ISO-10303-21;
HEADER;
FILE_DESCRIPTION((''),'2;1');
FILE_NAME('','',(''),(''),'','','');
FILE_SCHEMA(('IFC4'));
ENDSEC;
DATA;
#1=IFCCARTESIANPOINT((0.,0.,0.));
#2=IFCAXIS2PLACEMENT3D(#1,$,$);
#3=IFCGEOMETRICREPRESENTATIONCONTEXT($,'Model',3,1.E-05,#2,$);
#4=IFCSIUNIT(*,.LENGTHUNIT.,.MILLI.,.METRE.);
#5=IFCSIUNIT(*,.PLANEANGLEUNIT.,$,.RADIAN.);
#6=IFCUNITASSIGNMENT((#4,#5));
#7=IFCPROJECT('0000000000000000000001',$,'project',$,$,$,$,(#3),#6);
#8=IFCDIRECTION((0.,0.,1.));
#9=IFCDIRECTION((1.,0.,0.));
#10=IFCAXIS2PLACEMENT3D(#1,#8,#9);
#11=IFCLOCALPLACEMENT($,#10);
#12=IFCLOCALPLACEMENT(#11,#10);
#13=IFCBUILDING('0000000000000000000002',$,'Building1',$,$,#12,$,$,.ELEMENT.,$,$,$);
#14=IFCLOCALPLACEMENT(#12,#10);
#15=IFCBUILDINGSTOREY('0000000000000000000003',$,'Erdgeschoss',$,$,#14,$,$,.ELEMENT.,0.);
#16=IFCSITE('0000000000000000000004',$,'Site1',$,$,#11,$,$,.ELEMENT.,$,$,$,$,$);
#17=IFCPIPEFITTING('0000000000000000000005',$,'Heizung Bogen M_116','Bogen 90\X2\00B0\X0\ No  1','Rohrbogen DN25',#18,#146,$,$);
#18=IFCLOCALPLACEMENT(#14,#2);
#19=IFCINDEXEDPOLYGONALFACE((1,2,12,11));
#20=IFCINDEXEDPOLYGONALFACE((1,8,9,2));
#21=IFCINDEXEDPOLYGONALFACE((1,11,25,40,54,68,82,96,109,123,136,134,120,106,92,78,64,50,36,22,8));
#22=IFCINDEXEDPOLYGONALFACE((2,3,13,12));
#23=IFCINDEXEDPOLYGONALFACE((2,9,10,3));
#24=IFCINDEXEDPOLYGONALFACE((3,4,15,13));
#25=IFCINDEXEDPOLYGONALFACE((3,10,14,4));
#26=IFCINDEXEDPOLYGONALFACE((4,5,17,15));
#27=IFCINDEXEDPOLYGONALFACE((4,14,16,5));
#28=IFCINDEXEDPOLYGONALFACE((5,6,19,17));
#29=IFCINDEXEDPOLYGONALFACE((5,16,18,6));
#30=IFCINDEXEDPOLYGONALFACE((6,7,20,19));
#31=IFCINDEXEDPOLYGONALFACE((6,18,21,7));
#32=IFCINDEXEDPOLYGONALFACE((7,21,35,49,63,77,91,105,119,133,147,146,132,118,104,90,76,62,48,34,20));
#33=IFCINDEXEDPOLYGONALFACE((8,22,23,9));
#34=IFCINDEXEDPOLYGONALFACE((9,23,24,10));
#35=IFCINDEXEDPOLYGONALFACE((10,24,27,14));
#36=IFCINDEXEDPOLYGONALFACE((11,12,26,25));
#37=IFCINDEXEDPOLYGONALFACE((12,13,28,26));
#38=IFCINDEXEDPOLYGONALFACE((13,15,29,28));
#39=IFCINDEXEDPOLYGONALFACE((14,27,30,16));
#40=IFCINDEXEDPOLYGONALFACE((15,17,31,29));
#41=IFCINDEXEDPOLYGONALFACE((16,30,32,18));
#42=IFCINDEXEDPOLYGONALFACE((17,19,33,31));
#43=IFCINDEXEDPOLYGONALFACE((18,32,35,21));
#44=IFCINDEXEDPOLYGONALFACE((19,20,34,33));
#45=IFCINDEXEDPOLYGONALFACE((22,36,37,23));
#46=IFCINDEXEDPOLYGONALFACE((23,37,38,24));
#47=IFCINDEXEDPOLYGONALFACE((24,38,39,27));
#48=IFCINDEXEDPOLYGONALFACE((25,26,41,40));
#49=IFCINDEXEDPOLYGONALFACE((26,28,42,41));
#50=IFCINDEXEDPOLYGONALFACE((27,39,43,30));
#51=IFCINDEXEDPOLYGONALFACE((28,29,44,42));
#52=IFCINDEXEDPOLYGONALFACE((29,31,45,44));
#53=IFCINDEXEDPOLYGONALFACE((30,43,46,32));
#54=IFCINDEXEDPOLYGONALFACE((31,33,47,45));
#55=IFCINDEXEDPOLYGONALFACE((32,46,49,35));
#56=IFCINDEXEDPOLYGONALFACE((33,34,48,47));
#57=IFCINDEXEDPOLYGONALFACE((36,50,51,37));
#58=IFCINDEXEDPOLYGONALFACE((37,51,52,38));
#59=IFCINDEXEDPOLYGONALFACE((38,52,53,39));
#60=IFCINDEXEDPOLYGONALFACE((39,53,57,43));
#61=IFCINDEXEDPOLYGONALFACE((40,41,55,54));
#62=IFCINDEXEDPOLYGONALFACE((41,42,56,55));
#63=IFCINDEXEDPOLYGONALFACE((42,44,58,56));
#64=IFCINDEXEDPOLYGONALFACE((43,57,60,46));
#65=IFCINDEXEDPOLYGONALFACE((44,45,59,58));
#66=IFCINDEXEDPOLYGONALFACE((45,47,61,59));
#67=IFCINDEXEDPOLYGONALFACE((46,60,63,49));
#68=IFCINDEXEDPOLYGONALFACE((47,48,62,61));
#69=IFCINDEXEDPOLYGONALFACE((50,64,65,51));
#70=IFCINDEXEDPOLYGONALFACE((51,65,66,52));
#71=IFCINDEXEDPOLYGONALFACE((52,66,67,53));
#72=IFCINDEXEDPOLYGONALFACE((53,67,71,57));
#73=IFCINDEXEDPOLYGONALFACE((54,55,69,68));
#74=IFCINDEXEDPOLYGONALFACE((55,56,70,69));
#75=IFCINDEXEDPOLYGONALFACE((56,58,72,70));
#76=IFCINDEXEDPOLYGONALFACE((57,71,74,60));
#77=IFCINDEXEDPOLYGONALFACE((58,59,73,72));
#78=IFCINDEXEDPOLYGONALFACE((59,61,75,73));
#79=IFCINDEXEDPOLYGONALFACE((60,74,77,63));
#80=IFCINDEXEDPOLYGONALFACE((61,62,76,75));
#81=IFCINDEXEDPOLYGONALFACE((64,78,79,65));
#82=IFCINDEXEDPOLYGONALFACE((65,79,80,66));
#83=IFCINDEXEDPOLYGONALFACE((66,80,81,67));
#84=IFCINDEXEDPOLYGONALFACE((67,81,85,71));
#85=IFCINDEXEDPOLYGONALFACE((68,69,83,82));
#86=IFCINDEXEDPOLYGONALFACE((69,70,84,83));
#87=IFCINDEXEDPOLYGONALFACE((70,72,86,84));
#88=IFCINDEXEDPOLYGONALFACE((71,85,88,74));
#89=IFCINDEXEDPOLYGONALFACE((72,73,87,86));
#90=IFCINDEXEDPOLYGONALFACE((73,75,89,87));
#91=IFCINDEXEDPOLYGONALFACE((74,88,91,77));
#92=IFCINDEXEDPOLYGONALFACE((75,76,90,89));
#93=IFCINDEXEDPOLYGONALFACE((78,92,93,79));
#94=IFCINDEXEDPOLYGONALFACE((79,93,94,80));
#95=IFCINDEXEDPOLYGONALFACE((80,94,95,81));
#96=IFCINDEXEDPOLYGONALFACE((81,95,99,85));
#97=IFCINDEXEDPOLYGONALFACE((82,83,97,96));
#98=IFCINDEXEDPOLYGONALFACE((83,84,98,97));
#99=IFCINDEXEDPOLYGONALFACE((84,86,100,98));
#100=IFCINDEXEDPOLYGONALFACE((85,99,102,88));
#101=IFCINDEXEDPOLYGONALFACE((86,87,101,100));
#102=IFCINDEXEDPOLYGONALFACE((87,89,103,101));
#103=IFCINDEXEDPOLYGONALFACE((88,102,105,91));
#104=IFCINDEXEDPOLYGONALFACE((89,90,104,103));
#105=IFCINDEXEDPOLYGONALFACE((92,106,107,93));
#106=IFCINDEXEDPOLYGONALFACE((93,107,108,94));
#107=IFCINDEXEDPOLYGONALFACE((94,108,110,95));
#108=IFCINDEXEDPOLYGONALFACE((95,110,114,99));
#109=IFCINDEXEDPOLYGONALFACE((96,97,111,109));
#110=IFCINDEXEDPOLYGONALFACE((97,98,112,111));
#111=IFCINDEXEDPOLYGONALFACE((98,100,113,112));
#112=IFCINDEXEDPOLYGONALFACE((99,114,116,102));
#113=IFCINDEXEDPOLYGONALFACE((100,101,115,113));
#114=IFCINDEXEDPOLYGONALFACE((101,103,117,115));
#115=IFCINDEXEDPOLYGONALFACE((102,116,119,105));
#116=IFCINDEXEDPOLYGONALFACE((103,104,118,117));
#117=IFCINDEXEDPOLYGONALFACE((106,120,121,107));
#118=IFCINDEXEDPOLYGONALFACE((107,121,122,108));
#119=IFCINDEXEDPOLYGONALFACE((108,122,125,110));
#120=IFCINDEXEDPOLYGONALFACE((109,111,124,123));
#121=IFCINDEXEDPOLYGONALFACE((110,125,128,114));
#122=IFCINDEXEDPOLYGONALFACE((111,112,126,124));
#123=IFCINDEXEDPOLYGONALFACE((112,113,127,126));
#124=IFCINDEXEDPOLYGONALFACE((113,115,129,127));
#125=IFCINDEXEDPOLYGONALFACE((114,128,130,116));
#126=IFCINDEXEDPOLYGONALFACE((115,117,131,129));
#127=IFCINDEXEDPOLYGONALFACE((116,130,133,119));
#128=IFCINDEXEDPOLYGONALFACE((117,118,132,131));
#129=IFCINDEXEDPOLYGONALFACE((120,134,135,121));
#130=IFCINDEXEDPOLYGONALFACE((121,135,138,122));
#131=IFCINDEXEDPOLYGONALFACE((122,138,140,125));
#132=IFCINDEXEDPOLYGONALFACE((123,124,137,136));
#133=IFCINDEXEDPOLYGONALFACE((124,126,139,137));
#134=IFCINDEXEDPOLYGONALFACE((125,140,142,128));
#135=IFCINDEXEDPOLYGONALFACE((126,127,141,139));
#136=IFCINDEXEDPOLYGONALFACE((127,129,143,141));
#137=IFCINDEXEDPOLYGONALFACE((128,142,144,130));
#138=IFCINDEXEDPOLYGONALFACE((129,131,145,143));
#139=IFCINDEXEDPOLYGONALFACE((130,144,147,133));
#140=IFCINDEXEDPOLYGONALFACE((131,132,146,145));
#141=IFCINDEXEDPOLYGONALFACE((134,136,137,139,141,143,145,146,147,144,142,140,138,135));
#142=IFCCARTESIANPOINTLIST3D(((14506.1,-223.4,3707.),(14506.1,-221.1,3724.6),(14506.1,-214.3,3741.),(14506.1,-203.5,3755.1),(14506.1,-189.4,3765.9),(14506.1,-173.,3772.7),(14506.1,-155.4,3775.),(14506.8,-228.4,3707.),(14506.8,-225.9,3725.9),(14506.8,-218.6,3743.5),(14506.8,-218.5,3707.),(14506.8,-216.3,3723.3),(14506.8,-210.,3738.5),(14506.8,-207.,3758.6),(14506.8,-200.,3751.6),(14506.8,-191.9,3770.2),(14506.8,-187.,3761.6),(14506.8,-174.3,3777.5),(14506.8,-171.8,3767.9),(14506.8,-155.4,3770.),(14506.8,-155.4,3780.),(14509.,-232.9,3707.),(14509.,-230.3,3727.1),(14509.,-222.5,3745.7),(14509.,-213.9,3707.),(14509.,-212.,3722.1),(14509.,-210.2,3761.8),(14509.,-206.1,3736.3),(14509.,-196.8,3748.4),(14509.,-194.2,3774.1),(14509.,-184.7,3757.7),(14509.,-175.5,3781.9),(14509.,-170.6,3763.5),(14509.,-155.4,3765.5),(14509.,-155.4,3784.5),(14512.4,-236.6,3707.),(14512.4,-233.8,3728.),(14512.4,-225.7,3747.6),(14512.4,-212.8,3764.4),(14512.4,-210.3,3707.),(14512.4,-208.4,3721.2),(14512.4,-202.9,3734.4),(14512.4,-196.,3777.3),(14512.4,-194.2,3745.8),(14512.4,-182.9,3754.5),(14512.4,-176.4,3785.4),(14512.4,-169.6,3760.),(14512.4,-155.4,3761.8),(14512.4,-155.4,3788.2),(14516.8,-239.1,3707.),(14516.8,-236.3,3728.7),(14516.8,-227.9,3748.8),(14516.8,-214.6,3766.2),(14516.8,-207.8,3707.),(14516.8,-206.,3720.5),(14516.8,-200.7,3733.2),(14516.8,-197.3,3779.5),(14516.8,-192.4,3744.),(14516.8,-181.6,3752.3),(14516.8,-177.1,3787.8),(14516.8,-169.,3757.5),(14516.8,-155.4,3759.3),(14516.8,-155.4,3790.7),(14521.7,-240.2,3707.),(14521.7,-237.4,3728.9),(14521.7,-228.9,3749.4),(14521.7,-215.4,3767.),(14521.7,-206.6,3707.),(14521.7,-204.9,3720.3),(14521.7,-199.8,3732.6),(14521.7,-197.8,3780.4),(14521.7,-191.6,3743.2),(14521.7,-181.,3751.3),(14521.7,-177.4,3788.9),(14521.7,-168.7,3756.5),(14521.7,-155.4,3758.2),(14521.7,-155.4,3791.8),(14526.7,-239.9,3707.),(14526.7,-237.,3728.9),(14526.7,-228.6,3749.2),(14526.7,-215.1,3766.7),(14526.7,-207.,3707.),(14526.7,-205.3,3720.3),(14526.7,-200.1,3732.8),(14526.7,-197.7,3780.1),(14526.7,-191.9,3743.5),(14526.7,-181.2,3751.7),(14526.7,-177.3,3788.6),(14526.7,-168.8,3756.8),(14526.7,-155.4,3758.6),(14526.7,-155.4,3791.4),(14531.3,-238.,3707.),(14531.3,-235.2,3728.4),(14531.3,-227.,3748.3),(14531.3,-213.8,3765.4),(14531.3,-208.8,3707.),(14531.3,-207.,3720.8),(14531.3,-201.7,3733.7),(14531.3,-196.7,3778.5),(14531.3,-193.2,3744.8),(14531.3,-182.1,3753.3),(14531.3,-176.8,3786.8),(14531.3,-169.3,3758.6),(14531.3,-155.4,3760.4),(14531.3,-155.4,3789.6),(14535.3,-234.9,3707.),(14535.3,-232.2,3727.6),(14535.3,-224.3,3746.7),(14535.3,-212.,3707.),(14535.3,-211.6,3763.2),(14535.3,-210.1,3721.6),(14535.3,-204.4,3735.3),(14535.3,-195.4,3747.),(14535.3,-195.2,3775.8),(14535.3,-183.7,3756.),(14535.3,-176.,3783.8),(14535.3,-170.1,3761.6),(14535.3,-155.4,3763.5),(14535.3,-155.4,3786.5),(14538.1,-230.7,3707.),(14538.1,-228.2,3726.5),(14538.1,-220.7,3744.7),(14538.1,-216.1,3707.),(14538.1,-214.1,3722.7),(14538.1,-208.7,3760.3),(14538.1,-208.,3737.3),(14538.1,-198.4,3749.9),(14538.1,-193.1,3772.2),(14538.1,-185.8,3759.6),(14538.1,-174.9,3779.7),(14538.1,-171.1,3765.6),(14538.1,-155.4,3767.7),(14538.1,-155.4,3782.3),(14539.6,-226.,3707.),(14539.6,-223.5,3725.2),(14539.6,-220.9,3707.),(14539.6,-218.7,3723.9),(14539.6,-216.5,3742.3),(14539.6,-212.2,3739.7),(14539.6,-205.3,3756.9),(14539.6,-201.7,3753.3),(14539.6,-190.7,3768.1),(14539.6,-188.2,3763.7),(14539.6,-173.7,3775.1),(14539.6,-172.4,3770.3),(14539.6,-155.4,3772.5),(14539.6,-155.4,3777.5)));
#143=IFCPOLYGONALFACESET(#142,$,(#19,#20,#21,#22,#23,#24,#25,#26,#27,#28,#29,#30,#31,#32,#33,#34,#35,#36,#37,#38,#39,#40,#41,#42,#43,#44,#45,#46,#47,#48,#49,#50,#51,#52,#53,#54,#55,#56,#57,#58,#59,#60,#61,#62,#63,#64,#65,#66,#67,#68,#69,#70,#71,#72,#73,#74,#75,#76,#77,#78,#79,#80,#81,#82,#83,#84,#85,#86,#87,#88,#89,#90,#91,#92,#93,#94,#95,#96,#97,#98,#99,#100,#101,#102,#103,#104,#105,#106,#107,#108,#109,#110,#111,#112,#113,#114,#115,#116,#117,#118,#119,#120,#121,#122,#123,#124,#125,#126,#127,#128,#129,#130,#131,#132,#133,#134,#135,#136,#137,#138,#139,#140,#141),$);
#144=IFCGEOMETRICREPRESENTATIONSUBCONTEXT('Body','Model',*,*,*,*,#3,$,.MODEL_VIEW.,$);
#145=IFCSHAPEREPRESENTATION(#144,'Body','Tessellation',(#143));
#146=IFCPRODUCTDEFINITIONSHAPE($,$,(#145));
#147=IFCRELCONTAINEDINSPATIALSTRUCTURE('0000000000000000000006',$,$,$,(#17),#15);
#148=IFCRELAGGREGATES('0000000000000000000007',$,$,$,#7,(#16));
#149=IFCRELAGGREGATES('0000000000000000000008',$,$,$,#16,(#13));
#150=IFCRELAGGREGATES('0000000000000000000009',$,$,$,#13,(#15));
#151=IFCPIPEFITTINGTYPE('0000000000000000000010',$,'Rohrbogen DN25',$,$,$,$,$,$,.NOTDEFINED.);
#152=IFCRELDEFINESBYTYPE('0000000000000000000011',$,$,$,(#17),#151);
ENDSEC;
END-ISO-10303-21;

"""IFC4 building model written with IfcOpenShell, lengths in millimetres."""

from ifc_helpers import new_model, entity, si_unit, frame, origin, origin_with_axes, place, context, subcontext, project, spatial, shape, source, transform, mapped, type_object, element, save


model = new_model("IFC4")

# Units and contexts
model_context = context("Model", 3, precision=1e-05, world=origin())
body_context = subcontext(model_context, "Body", "Model", "MODEL_VIEW")
ifc_project = project(units=[si_unit("LENGTHUNIT", "METRE", prefix="MILLI"), si_unit("PLANEANGLEUNIT", "RADIAN")], contexts=[model_context])

# Site, building, storey
site_placement = place(None, origin_with_axes())
site = spatial("IfcSite", under=ifc_project, at=site_placement, Name="Site1", CompositionType="ELEMENT")
building_placement = place(site_placement, origin_with_axes())
building = spatial("IfcBuilding", under=site, at=building_placement, Name="Building1", CompositionType="ELEMENT")
storey_placement = place(building_placement, origin_with_axes())
storey = spatial("IfcBuildingStorey", under=building, at=storey_placement, Name="Erdgeschoss", CompositionType="ELEMENT", Elevation=0.0)

# Pipe fitting
pipe_fitting_type = type_object("IfcPipeFittingType", Name="Rohrbogen DN25", PredefinedType="NOTDEFINED")
shared_shape_1 = source(origin_with_axes(), body_context, "Body", "SolidModel", [
    entity("IfcRevolvedAreaSolid", entity("IfcCircleProfileDef", "AREA", None, entity("IfcAxis2Placement2D", entity("IfcCartesianPoint", [0.0, 0.0]), entity("IfcDirection", [1.0, 0.0])), 16.9), entity("IfcAxis2Placement3D", entity("IfcCartesianPoint", [-42.4, 0.0, 25.6]), entity("IfcDirection", [1.0, 0.0, 0.0]), entity("IfcDirection", [0.0, -1.0, 0.0])), entity("IfcAxis1Placement", entity("IfcCartesianPoint", [0.0, 68.0, 0.0]), entity("IfcDirection", [-1.0, 0.0, 0.0])), 1.570796),
])
pipe_fitting_1_placement = place(storey_placement, frame((14522.9, -197.9, 3749.4), z_axis=(0.0, 0.0, 1.0), x_axis=(1.0, 0.0, 0.0)))
element("IfcPipeFitting", 1, at=pipe_fitting_1_placement, inside=storey, type_object=pipe_fitting_type, Name="Heizung Bogen M_116", Description="Bogen 90° No  1", ObjectType="Rohrbogen DN25", shapes=[
    shape(body_context, "Body", "MappedRepresentation", [mapped(shared_shape_1, transform((0.0, 0.0, 0.0), x_axis=(0.0, -1.0, 0.0), y_axis=(1.0, 0.0, 0.0), z_axis=(0.0, 0.0, 1.0), scale=1.0))]),
    shape(body_context, "Body", "MappedRepresentation", [mapped(shared_shape_1, transform((0.0, 0.0, 0.0), x_axis=(0.0, -1.0, 0.0), y_axis=(1.0, 0.0, 0.0), z_axis=(0.0, 0.0, 1.0), scale=1.0))]),
])

save(model, "model.ifc")
